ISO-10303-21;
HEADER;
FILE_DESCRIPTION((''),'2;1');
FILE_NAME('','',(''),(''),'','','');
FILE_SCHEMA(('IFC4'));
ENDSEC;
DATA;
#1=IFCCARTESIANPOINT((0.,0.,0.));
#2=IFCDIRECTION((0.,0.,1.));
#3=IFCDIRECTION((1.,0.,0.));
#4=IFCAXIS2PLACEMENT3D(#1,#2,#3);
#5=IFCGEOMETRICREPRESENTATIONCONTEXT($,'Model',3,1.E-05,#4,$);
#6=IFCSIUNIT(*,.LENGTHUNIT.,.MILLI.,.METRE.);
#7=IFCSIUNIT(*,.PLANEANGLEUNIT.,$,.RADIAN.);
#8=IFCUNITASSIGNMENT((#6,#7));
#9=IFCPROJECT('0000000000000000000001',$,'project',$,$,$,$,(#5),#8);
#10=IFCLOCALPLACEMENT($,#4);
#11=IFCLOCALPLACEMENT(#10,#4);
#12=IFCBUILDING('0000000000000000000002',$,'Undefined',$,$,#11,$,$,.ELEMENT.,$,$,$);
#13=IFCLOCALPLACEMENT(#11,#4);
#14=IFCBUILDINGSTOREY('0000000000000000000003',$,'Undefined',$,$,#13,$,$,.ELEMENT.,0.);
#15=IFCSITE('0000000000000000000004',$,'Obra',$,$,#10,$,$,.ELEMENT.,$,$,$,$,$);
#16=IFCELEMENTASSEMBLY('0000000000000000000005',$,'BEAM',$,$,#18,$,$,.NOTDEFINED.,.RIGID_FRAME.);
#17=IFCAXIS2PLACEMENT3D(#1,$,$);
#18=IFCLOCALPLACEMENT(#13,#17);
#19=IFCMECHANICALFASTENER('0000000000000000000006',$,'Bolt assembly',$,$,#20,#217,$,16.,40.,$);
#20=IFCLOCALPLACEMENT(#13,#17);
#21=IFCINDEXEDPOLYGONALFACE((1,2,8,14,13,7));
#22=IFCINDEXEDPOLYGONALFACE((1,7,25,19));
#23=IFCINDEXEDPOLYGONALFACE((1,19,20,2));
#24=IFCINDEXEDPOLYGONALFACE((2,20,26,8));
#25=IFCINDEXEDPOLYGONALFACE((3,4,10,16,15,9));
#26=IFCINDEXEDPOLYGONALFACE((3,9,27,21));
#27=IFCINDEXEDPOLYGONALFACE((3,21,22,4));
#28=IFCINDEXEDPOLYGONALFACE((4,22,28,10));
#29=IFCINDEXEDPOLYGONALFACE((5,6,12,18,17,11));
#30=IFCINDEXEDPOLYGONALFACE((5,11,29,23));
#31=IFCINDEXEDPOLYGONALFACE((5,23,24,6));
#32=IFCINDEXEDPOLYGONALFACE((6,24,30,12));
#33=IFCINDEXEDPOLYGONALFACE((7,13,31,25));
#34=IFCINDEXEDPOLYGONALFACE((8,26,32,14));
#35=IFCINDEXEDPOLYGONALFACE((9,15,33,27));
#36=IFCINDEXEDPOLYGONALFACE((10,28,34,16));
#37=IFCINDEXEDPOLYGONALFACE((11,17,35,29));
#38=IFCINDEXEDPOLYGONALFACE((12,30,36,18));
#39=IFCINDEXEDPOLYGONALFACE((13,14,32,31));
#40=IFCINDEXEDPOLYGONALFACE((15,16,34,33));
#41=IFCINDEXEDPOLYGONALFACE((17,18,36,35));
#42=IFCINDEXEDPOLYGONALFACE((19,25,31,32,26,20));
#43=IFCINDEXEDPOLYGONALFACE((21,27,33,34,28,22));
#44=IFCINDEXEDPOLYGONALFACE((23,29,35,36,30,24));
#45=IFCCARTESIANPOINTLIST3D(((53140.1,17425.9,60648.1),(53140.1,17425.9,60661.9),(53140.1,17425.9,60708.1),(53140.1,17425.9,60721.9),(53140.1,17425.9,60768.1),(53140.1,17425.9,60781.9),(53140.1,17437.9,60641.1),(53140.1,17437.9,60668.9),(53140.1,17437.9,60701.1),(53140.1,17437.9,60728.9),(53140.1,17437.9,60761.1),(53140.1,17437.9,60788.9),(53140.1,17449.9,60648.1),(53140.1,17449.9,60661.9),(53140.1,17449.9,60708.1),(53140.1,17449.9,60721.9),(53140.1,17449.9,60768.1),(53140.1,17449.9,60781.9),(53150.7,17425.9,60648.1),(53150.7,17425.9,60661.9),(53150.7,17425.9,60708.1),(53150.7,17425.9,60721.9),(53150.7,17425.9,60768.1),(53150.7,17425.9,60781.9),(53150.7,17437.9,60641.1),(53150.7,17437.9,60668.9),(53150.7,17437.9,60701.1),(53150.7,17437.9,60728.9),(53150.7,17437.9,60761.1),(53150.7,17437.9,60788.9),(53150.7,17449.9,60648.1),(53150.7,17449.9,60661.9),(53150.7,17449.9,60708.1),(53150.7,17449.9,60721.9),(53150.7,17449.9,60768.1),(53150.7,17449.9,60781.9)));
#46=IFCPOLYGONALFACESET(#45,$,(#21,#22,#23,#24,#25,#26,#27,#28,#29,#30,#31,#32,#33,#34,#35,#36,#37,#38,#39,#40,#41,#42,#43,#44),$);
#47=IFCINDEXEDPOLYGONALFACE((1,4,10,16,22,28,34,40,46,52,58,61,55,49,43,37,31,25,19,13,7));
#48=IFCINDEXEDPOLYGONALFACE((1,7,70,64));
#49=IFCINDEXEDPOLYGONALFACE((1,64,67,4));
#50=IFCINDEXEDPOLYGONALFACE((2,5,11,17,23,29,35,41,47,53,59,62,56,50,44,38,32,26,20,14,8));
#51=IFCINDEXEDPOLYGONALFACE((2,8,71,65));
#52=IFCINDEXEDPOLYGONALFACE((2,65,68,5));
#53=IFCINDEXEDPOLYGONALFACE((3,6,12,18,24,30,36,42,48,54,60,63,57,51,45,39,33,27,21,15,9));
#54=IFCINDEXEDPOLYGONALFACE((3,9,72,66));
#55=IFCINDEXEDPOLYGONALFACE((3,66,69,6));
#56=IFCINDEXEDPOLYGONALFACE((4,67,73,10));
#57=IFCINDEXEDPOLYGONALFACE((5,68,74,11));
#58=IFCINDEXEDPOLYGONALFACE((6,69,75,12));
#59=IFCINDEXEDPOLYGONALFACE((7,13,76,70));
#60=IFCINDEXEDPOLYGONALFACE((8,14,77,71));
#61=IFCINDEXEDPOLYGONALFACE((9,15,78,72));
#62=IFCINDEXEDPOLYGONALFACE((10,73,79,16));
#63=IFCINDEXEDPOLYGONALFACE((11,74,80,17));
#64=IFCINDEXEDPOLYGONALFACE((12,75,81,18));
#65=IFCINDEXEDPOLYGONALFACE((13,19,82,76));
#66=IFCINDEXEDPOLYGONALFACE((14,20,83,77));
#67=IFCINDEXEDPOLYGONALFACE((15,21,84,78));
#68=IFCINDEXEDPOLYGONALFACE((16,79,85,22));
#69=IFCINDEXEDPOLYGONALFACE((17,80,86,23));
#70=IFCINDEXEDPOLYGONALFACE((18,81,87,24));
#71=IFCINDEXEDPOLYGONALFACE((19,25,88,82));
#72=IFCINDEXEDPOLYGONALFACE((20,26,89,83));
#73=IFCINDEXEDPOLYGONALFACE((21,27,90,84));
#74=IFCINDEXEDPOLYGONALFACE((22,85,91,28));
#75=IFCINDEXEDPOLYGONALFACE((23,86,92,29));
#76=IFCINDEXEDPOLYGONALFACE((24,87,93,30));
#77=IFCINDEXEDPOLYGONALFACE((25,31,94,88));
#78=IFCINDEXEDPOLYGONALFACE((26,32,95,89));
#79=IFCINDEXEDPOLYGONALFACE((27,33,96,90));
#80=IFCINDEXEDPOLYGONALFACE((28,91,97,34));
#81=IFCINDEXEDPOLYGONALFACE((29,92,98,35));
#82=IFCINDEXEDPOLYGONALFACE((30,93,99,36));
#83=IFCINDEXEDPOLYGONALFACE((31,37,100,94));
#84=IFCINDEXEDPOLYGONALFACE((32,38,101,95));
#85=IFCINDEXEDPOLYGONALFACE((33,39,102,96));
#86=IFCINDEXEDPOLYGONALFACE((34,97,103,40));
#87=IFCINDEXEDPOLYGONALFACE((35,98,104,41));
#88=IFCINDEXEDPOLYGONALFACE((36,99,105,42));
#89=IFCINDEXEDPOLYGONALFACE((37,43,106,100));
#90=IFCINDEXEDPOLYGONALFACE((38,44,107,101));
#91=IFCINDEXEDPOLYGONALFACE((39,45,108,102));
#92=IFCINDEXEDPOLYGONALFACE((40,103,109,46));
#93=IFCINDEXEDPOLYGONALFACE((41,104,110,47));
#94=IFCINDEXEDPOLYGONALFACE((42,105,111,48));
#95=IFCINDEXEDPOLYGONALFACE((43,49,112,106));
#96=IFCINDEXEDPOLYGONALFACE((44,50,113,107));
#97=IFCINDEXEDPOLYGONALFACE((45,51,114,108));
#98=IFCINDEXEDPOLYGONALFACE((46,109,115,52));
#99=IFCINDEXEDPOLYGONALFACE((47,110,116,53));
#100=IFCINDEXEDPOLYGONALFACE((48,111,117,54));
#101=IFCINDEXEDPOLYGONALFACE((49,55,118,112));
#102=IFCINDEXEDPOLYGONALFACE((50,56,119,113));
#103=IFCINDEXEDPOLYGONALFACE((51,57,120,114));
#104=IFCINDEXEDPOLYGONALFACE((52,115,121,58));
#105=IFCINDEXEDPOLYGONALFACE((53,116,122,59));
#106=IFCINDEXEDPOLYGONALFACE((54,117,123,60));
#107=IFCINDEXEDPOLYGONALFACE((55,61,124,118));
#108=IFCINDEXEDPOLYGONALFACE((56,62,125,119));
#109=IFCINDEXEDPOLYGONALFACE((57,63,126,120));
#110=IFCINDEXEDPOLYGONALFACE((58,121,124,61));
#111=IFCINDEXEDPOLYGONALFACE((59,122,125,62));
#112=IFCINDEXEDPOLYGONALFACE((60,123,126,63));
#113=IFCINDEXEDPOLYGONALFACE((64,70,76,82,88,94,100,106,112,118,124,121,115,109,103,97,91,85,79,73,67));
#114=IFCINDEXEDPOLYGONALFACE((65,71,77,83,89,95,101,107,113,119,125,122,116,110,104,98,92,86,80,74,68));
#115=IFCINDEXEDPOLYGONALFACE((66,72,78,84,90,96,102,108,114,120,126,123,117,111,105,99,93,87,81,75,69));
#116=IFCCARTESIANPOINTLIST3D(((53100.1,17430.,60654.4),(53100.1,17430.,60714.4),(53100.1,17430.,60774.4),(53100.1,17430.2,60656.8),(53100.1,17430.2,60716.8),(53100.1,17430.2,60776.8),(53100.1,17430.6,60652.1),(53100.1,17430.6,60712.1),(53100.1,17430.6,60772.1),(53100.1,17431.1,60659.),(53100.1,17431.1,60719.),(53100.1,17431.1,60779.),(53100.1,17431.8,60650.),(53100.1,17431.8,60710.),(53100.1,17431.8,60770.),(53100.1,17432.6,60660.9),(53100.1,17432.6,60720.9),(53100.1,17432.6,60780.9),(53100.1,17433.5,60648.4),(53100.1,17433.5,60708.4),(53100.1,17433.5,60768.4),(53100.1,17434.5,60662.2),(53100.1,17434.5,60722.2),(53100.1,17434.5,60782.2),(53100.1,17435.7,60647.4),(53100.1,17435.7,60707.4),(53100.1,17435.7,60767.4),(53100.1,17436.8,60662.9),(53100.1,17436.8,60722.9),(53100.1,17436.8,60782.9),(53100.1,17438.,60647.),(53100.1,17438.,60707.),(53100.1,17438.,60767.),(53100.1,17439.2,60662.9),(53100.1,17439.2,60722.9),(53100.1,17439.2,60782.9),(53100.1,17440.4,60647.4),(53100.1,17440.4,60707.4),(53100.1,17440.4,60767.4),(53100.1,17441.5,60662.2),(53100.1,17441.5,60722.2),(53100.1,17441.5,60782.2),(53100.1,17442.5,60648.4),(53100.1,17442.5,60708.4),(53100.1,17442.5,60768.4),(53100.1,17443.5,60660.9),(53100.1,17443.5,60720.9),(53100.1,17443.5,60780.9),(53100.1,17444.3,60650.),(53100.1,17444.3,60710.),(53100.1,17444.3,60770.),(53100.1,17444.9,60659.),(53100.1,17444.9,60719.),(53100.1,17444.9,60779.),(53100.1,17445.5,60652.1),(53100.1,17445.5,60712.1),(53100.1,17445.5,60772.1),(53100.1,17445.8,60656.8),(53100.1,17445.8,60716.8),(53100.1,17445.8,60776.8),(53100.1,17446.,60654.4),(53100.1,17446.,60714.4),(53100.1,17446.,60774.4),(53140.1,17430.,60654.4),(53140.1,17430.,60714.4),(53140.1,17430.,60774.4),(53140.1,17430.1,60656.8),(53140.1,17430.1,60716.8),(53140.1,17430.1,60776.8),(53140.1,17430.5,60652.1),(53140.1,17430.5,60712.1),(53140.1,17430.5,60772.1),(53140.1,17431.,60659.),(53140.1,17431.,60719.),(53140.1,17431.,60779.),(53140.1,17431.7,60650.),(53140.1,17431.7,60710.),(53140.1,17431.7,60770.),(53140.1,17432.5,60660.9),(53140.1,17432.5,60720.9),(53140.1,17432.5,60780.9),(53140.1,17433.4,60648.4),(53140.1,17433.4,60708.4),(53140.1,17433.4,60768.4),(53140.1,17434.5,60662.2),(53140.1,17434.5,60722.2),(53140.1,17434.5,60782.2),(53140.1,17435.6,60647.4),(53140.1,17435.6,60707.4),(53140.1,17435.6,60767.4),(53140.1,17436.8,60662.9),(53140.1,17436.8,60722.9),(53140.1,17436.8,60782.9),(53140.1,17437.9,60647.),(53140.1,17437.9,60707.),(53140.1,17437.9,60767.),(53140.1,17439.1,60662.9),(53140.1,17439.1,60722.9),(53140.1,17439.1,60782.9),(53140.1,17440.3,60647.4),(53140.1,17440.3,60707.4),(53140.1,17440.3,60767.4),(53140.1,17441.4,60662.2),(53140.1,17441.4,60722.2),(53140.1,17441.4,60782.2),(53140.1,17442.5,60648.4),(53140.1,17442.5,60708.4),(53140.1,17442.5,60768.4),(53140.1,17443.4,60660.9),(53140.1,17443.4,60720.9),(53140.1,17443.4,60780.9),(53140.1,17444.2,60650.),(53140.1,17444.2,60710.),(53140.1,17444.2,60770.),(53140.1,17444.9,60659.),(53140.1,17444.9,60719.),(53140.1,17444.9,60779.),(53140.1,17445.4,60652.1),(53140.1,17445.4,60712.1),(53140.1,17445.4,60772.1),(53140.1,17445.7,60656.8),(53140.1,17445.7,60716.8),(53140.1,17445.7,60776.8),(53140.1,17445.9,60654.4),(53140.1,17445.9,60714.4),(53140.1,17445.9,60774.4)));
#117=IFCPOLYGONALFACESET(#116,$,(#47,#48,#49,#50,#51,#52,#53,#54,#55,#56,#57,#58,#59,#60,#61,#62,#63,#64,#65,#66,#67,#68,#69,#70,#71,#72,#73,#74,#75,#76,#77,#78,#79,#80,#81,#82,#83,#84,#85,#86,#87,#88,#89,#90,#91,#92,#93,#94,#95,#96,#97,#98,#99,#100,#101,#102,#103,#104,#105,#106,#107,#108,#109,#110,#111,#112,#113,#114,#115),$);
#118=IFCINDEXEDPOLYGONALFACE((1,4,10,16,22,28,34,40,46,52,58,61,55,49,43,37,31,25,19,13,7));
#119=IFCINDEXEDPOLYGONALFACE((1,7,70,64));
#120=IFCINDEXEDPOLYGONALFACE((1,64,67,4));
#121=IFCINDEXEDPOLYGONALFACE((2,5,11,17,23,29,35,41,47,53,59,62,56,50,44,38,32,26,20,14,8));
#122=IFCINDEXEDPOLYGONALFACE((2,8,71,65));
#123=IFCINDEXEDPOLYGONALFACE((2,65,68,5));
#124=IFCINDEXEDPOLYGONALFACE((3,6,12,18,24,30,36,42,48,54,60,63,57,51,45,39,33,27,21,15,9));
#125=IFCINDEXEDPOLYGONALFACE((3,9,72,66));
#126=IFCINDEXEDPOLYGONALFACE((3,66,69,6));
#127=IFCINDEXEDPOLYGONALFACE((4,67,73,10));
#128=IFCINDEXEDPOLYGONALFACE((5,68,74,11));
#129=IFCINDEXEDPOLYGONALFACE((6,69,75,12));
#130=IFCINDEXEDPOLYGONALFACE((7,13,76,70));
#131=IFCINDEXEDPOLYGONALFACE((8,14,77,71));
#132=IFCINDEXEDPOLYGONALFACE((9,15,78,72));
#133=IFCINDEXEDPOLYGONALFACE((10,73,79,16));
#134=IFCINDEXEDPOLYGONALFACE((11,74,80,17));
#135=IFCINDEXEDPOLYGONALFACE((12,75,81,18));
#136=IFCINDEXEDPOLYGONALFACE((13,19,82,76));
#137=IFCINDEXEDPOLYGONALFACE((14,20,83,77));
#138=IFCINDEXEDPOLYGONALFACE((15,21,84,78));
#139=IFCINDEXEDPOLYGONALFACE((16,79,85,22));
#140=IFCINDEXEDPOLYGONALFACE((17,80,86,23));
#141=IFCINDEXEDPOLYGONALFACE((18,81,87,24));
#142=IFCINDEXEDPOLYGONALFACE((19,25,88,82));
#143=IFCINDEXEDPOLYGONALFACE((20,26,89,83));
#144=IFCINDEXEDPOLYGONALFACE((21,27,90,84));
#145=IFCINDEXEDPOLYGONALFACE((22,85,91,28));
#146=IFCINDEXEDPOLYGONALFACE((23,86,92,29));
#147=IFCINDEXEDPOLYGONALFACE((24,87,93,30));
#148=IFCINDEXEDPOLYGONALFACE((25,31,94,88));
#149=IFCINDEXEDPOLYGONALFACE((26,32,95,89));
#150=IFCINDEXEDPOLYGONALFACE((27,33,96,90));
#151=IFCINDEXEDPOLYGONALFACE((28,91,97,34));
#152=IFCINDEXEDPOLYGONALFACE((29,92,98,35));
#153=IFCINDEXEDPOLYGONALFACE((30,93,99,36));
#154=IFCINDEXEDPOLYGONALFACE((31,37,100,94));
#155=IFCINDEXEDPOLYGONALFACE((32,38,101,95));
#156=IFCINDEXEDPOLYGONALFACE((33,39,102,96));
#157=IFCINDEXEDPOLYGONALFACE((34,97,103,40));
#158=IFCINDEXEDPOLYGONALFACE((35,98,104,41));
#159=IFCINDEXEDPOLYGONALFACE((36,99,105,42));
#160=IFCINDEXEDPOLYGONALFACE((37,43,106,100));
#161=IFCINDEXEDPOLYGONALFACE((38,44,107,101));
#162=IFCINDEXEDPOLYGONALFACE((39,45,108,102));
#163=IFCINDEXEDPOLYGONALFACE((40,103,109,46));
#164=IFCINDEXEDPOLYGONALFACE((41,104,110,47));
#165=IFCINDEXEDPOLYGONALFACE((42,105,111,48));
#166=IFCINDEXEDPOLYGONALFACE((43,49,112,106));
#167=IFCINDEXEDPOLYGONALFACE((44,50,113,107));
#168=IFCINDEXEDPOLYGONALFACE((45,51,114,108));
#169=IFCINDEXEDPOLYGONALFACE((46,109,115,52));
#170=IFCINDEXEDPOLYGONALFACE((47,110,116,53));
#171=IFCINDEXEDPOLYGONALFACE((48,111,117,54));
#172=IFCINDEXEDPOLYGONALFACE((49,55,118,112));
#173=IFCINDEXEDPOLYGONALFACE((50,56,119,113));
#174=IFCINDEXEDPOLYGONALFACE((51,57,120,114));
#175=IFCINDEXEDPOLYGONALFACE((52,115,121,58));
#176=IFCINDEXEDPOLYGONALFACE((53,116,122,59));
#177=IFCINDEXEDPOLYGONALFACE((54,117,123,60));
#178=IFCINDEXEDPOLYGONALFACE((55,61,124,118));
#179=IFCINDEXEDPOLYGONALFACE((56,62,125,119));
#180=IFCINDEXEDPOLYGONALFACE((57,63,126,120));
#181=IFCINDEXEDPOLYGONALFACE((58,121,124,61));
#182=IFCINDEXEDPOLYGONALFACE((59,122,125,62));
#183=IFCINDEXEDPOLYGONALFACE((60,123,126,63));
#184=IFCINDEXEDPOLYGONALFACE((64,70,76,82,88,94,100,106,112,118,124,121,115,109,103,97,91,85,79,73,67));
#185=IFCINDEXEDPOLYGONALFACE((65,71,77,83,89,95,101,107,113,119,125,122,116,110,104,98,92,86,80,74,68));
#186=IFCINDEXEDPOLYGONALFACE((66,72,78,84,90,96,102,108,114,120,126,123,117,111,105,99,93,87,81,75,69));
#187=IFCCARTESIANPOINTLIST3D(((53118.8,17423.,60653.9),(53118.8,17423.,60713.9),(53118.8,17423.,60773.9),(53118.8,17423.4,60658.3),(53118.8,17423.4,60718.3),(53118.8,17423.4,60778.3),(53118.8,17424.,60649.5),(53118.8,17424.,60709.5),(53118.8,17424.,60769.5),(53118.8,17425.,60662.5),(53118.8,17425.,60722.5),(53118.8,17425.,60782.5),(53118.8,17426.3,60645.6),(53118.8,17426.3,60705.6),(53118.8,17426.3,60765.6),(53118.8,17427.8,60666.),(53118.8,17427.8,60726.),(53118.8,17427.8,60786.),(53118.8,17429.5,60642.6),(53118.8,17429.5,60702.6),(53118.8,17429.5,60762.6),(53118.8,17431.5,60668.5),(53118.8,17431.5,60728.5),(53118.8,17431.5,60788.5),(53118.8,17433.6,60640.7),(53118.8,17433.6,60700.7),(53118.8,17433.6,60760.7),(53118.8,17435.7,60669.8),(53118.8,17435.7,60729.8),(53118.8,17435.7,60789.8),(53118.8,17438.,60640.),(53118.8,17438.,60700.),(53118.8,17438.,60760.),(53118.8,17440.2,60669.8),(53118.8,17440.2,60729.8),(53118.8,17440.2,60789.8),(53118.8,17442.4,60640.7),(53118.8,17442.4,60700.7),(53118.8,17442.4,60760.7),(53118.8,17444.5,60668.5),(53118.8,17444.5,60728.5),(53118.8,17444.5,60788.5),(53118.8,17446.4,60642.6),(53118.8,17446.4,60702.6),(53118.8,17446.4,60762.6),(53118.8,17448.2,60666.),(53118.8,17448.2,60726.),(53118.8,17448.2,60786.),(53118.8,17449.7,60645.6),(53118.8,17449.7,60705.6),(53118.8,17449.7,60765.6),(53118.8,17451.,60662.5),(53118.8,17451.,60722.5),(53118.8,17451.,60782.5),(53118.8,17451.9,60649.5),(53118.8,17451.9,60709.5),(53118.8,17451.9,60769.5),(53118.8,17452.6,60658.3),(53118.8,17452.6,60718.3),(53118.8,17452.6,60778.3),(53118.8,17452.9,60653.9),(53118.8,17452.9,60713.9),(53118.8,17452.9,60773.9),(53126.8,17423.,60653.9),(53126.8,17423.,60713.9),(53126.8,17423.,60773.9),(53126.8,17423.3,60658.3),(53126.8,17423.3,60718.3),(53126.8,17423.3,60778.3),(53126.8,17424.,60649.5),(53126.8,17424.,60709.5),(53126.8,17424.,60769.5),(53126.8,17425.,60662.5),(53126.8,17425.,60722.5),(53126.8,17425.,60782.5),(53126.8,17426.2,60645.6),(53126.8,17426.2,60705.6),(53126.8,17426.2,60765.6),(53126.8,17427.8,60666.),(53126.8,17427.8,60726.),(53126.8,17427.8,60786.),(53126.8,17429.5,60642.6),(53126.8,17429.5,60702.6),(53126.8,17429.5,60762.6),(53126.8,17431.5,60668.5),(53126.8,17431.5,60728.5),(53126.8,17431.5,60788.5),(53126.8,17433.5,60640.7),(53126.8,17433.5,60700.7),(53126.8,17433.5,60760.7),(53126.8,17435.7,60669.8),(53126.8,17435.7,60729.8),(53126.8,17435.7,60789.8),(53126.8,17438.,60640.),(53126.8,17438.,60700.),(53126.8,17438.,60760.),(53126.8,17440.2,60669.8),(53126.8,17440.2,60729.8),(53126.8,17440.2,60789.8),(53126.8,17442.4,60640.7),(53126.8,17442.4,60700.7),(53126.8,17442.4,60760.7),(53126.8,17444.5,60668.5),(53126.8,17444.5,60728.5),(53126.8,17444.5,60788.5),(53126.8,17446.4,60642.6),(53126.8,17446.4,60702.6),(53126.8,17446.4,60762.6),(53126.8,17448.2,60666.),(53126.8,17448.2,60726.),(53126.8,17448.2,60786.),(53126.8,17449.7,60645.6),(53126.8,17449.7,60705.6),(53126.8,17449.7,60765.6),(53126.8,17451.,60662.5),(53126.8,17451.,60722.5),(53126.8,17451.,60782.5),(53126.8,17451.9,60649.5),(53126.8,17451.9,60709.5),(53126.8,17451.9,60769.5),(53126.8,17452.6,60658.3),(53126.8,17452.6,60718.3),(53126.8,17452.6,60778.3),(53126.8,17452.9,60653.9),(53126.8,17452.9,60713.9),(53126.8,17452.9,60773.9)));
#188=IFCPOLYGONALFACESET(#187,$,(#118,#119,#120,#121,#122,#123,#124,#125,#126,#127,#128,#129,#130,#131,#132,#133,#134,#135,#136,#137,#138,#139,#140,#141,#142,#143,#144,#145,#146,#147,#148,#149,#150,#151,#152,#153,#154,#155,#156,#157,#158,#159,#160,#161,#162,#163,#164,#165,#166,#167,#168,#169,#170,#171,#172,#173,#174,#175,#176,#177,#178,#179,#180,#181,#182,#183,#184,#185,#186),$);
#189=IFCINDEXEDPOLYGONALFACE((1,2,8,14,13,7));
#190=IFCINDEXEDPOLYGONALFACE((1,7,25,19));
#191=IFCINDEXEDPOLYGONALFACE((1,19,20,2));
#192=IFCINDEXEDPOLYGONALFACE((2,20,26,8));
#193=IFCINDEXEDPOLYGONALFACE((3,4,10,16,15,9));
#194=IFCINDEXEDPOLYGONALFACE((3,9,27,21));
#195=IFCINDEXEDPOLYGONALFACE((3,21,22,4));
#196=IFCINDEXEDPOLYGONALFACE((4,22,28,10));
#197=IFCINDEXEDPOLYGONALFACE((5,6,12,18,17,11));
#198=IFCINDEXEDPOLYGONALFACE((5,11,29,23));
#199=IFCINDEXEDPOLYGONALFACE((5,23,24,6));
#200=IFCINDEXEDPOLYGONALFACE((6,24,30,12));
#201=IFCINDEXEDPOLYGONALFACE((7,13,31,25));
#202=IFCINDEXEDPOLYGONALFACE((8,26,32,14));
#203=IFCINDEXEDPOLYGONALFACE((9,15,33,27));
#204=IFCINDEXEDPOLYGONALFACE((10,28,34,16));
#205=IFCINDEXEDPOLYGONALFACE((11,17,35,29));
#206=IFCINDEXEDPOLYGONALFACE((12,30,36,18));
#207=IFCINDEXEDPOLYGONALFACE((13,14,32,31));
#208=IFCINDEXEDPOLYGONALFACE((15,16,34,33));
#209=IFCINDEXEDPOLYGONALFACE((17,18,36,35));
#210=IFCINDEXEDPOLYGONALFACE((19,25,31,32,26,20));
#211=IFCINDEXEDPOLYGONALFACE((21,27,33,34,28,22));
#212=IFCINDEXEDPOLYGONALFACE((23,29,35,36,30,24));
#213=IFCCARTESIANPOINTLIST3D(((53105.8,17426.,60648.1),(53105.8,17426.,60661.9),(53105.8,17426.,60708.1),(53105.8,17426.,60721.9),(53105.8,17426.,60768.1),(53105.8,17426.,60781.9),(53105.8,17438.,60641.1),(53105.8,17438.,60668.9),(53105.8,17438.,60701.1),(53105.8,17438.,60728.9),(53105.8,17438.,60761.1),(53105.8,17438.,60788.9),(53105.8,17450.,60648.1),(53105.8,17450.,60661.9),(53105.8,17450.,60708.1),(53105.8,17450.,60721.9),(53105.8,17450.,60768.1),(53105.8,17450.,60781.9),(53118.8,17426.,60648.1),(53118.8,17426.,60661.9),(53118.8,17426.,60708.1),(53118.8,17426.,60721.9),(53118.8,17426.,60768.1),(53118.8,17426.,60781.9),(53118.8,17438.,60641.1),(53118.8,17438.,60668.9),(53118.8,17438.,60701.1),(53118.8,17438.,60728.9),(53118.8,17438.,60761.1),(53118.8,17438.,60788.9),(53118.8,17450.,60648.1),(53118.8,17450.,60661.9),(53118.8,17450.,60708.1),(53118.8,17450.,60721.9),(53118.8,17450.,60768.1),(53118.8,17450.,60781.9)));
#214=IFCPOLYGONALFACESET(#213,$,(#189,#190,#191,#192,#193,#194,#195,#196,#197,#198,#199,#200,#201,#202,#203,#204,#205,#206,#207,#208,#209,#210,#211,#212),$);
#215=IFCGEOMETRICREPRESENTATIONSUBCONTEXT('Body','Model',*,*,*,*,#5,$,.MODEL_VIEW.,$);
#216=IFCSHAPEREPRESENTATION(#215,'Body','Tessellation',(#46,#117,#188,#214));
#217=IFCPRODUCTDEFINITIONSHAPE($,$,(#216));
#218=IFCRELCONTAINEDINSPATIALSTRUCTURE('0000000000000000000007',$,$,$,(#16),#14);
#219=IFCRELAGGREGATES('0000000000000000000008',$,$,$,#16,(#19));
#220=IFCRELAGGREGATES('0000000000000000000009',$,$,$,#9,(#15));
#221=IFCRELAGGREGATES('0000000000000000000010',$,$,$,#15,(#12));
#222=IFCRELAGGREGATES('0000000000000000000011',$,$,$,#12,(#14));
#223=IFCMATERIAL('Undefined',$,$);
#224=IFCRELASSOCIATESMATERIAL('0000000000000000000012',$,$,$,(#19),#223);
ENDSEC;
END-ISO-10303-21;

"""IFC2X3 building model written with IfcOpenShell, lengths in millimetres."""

from ifc_helpers import new_model, si_unit, frame, origin_with_axes, origin_2d_with_axis, place, context, subcontext, project, spatial, polyline, circle, outline, extrude, source, transform, mapped, material, element, aggregate, save


model = new_model("IFC2X3")

# Units and contexts
model_context = context("Model", 3, precision=1e-05, world=origin_with_axes())
body_context = subcontext(model_context, "Body", "Model", "MODEL_VIEW")
ifc_project = project(units=[si_unit("LENGTHUNIT", "METRE", prefix="MILLI"), si_unit("PLANEANGLEUNIT", "RADIAN")], contexts=[model_context])

# Site, building, storey
site_placement = place(None, origin_with_axes())
site = spatial("IfcSite", under=ifc_project, at=site_placement, Name="Obra", CompositionType="ELEMENT")
building_placement = place(site_placement, origin_with_axes())
building = spatial("IfcBuilding", under=site, at=building_placement, Name="Undefined", CompositionType="ELEMENT")
storey_placement = place(building_placement, origin_with_axes())
storey = spatial("IfcBuildingStorey", under=building, at=storey_placement, Name="Undefined", CompositionType="ELEMENT", Elevation=0.0)

# Element assembly, mechanical fastener
ifc_material_1 = material(Name="Undefined")
assembly_1_placement = place(storey_placement, origin_with_axes())
assembly_1 = element("IfcElementAssembly", 1, at=assembly_1_placement, inside=storey, Name="BEAM", AssemblyPlace="NOTDEFINED", PredefinedType="RIGID_FRAME")
shared_shape_1 = source(origin_with_axes(), body_context, "Body", "SweptSolid", [
    extrude(outline(polyline([(13.9, 0.0), (6.9, 12.0), (-6.9, 12.0), (-13.9, 0.0), (-6.9, -12.0), (6.9, -12.0), (13.9, 0.0)])), frame((0.0, -19.7, 0.0), z_axis=(0.0, 1.0, 0.0), x_axis=(1.0, 0.0, 0.0)), (0.0, 0.0, 1.0), 10.6),
    extrude(circle(Radius=8.0, at=origin_2d_with_axis()), frame((0.0, -9.1, 0.0), z_axis=(0.0, 1.0, 0.0), x_axis=(1.0, 0.0, 0.0)), (0.0, 0.0, 1.0), 40.0),
    extrude(circle(Radius=15.0, at=origin_2d_with_axis()), frame((0.0, 4.2, 0.0), z_axis=(0.0, 1.0, 0.0), x_axis=(1.0, 0.0, 0.0)), (0.0, 0.0, 1.0), 8.0),
    extrude(outline(polyline([(13.9, 0.0), (6.9, 12.0), (-6.9, 12.0), (-13.9, 0.0), (-6.9, -12.0), (6.9, -12.0), (13.9, 0.0)])), frame((0.0, 12.2, 0.0), z_axis=(0.0, 1.0, 0.0), x_axis=(1.0, 0.0, 0.0)), (0.0, 0.0, 1.0), 13.0),
])
mechanical_fastener_1_placement = place(assembly_1_placement, frame((53130.9, 17388.0, 60835.0), z_axis=(0.001649, 0.999999, 0.0), x_axis=(0.0, 0.0, -1.0)))
mechanical_fastener_1 = element("IfcMechanicalFastener", 2, at=mechanical_fastener_1_placement, material=ifc_material_1, Name="Bolt assembly", NominalDiameter=16.0, NominalLength=40.0, context=body_context, shape_type="MappedRepresentation", body=[
    mapped(shared_shape_1, transform((60.0, 0.0, 50.0))),
    mapped(shared_shape_1, transform((120.0, 0.0, 50.0))),
    mapped(shared_shape_1, transform((180.0, 0.0, 50.0))),
])
aggregate(assembly_1, [mechanical_fastener_1])

save(model, "model.ifc")
